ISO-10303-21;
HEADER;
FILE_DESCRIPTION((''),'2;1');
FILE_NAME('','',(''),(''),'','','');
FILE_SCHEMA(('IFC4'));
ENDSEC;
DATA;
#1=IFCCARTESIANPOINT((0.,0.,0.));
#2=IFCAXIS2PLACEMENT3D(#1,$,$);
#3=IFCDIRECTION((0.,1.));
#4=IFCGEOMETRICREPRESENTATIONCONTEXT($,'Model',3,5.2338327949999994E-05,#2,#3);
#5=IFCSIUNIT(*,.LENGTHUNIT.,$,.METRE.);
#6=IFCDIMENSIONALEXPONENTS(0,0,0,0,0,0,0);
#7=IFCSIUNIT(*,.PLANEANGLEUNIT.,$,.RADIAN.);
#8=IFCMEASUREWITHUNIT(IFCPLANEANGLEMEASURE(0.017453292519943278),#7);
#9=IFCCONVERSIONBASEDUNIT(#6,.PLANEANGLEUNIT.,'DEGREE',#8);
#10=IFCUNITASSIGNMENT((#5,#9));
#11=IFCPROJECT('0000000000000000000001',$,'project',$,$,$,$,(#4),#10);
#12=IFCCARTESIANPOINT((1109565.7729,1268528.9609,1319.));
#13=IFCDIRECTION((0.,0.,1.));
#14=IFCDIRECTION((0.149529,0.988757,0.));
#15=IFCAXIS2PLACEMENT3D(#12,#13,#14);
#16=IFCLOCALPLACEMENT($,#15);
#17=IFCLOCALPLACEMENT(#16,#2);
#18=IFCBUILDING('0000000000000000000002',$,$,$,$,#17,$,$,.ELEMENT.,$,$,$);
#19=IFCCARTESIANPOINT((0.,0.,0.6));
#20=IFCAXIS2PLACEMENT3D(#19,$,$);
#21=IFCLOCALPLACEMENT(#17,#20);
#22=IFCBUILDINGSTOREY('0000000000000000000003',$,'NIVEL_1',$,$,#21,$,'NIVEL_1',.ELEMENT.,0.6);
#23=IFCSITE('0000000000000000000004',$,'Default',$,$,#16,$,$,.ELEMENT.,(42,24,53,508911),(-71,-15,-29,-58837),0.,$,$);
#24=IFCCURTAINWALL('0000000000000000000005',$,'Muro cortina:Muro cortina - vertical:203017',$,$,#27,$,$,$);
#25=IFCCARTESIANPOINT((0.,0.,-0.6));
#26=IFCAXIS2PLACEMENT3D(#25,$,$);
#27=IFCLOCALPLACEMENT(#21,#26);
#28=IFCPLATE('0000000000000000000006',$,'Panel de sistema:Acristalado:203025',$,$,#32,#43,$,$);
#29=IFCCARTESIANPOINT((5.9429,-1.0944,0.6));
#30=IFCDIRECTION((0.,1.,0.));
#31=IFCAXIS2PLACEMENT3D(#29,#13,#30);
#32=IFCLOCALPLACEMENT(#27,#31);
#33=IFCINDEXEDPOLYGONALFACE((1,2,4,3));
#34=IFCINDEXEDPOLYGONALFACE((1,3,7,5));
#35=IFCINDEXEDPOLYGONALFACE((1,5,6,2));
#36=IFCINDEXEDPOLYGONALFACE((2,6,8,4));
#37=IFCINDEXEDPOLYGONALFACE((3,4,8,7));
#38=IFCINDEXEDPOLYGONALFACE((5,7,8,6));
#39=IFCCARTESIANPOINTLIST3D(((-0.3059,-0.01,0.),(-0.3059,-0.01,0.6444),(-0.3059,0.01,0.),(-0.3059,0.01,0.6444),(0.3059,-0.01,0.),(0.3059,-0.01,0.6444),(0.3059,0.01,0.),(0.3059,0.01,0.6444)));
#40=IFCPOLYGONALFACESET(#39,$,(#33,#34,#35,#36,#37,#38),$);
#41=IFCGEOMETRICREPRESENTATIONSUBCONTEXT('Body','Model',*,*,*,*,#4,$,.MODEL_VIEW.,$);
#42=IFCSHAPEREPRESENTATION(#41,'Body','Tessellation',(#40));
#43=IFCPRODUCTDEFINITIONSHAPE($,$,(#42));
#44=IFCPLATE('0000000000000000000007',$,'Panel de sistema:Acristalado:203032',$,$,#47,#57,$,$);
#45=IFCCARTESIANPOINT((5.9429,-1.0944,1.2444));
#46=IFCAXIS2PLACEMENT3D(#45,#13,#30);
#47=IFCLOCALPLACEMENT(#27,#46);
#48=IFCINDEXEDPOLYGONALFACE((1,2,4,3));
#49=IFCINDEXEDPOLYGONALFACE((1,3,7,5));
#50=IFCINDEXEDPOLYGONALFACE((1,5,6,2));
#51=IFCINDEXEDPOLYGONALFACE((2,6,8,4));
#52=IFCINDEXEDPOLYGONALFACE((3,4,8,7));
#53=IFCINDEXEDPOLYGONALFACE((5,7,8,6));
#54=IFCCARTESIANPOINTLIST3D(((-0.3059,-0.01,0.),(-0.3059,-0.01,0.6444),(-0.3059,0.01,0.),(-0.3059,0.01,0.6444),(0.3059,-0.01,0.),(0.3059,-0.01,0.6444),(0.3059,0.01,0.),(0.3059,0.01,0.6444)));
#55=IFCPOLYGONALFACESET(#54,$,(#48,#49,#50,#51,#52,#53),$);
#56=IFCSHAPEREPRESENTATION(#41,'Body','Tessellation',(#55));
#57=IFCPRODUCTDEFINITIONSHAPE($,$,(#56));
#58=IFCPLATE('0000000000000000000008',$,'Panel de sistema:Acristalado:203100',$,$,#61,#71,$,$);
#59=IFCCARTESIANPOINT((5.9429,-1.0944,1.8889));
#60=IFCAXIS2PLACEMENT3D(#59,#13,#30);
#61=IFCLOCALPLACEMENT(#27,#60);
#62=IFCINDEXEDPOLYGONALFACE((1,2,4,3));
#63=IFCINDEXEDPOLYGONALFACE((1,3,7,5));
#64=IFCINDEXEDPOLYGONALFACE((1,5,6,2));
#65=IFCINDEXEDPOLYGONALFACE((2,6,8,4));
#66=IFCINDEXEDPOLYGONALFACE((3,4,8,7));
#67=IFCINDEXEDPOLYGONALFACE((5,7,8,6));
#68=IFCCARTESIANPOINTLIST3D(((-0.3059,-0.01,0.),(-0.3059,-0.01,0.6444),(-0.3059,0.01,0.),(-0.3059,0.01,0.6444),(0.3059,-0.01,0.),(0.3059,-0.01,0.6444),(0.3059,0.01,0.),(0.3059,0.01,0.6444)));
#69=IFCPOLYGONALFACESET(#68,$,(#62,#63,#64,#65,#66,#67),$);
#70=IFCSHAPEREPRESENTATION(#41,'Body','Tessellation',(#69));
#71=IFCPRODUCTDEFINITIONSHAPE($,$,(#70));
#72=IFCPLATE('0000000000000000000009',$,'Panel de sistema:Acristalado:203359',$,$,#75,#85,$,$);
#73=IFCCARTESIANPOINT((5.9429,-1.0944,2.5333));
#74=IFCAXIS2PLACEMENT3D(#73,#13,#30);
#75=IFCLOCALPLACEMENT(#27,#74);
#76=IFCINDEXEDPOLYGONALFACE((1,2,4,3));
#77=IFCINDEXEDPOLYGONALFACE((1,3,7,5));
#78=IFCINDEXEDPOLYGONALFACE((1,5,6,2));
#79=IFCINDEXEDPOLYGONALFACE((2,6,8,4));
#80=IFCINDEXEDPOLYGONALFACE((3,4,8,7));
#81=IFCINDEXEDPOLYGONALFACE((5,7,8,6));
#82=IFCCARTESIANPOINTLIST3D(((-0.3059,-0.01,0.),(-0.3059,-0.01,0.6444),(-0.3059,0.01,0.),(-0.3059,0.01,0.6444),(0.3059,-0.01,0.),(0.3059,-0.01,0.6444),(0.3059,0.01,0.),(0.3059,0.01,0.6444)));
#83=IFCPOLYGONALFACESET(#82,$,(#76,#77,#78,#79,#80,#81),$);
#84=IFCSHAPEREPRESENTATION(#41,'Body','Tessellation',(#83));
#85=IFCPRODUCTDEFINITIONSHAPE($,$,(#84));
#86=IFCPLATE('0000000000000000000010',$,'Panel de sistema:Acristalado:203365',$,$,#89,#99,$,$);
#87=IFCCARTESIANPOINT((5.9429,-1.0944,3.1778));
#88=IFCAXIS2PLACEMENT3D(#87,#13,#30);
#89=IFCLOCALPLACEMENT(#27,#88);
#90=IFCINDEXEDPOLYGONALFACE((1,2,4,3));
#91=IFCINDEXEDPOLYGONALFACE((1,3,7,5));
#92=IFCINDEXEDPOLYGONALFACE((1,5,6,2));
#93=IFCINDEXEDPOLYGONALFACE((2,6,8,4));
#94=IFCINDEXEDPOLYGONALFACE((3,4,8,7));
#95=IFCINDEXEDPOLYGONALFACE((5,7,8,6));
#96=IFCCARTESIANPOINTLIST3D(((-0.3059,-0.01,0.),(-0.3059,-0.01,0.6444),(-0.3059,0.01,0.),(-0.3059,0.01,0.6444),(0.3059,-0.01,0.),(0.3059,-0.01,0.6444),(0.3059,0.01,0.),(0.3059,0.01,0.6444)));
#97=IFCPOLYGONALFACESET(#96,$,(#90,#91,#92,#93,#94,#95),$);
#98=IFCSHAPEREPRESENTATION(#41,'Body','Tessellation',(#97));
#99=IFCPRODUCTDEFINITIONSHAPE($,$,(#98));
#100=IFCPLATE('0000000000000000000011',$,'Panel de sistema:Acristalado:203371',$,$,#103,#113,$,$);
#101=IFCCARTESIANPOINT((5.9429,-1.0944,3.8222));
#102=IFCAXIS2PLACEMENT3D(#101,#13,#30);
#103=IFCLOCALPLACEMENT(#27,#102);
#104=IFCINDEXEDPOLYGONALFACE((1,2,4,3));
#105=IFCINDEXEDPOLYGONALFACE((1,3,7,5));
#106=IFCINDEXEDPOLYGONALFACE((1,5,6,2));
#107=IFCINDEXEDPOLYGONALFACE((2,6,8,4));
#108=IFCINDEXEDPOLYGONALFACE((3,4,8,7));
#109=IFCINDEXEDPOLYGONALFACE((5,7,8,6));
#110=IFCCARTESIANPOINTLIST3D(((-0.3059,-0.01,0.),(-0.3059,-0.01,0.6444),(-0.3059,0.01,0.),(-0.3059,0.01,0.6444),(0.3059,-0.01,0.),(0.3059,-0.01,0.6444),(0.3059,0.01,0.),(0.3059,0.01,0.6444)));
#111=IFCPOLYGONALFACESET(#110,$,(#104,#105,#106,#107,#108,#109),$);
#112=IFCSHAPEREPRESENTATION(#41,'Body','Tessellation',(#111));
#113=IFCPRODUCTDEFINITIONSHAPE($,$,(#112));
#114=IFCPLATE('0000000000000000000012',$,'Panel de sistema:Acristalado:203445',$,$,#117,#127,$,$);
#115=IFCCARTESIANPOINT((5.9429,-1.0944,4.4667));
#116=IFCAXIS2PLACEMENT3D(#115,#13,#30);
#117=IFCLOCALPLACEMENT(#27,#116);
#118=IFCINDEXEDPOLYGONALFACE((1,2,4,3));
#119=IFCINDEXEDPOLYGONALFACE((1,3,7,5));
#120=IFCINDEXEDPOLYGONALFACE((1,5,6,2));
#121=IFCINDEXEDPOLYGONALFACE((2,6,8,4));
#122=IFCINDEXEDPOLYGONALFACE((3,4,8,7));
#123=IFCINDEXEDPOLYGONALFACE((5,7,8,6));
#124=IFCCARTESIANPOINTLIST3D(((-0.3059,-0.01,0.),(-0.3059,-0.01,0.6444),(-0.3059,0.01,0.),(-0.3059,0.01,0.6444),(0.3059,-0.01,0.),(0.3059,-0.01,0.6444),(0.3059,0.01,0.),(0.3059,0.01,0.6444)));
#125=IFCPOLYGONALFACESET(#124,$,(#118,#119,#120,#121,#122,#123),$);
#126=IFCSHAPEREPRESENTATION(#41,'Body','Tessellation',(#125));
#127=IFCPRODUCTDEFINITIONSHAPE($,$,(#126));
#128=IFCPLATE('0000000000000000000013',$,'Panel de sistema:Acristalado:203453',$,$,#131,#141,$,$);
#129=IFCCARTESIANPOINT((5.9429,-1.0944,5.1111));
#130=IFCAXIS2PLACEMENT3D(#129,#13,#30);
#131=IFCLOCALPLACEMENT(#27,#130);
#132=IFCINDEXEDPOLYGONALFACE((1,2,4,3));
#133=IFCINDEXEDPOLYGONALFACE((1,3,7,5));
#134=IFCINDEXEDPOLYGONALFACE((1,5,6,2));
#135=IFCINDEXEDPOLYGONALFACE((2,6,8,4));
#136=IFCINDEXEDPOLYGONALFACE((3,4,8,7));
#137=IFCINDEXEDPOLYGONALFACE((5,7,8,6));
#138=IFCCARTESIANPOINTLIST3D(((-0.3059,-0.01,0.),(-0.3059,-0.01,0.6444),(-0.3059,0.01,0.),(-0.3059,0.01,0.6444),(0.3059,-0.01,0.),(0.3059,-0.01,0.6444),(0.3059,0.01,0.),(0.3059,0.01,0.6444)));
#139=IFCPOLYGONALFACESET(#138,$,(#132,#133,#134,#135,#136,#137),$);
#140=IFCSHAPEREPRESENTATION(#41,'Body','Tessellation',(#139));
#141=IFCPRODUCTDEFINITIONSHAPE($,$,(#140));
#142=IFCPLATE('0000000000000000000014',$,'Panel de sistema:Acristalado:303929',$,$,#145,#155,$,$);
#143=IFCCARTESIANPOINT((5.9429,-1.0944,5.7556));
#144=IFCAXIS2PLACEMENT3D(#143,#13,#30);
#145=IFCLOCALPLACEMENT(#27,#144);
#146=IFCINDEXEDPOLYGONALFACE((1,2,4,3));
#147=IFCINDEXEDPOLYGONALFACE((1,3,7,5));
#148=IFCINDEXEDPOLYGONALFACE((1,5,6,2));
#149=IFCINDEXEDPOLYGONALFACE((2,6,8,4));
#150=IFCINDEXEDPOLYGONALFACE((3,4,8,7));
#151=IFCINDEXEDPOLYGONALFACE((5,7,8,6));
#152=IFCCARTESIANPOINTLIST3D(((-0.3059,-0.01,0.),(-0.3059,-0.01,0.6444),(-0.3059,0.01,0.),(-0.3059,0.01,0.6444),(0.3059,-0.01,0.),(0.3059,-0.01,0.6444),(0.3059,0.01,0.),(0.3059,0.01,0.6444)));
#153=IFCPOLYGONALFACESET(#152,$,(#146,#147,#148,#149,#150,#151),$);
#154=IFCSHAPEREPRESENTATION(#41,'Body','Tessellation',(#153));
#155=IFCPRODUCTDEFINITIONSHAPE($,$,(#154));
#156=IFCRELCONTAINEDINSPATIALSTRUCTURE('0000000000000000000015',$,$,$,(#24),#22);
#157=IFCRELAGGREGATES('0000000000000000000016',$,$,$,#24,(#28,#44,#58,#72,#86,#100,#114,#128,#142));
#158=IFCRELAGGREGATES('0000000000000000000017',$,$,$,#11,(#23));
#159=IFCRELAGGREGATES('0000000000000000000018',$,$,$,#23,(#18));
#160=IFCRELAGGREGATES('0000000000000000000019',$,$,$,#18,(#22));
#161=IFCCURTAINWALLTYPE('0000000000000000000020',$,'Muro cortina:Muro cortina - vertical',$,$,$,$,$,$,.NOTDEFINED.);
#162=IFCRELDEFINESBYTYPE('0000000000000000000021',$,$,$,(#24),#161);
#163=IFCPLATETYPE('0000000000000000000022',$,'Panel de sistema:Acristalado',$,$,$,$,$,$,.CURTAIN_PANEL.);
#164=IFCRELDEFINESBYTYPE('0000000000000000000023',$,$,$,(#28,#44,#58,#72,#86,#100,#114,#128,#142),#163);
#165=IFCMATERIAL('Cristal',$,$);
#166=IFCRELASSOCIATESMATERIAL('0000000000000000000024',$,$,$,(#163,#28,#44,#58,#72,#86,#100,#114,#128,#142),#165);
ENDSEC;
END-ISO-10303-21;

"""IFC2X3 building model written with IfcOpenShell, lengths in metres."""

from ifc_helpers import new_model, entity, si_unit, converted_unit, direction, frame, frame_2d, origin, place, context, subcontext, project, spatial, rectangle, extrude, source, transform, mapped, material, type_object, type_shapes, element, aggregate, save


model = new_model("IFC2X3")

# Units and contexts
model_context = context("Model", 3, precision=5.2338327949999994e-05, world=origin(), true_north=direction((0.0, 1.0)))
body_context = subcontext(model_context, "Body", "Model", "MODEL_VIEW")
ifc_project = project(units=[si_unit("LENGTHUNIT", "METRE"), converted_unit("PLANEANGLEUNIT", "DEGREE", entity("IfcPlaneAngleMeasure", 0.017453292519943278), si_unit("PLANEANGLEUNIT", "RADIAN"), dimensions=[0, 0, 0, 0, 0, 0, 0])], contexts=[model_context])

# Site, building, storey
site_placement = place(None, frame((1109565.7729, 1268528.9609, 1319.0), z_axis=(0.0, 0.0, 1.0), x_axis=(0.149529, 0.988757, 0.0)))
site = spatial("IfcSite", under=ifc_project, at=site_placement, Name="Default", CompositionType="ELEMENT", RefLatitude=(42, 24, 53, 508911), RefLongitude=(-71, -15, -29, -58837), RefElevation=0.0)
building_placement = place(site_placement, origin())
building = spatial("IfcBuilding", under=site, at=building_placement, CompositionType="ELEMENT")
storey_placement = place(building_placement, frame((0.0, 0.0, 0.6)))
storey = spatial("IfcBuildingStorey", under=building, at=storey_placement, Name="NIVEL_1", LongName="NIVEL_1", CompositionType="ELEMENT", Elevation=0.6)

# Curtain wall, plates
curtain_wall_type = type_object("IfcCurtainWallType", Name="Muro cortina:Muro cortina - vertical", PredefinedType="NOTDEFINED")
curtain_wall_placement = place(storey_placement, frame((0.0, 0.0, -0.6)))
curtain_wall = element("IfcCurtainWall", 1, at=curtain_wall_placement, inside=storey, type_object=curtain_wall_type, Name="Muro cortina:Muro cortina - vertical:203017")
ifc_material = material(Name="Cristal")
plate_type = type_object("IfcPlateType", Name="Panel de sistema:Acristalado", PredefinedType="CURTAIN_PANEL", material=ifc_material)
shared_shape = source(origin(), body_context, "Body", "SweptSolid", [
    extrude(rectangle(XDim=0.02, YDim=0.6119, at=frame_2d((0.0, 0.0), x_axis=(1.0, 0.0))), frame((0.0, 0.0, 0.0), z_axis=(0.0, 0.0, 1.0), x_axis=(0.0, 1.0, 0.0)), (0.0, 0.0, 1.0), 0.6444),
])
type_shapes(plate_type, [shared_shape])
plate_1_placement = place(curtain_wall_placement, frame((5.9429, -1.0944, 0.6), z_axis=(0.0, 0.0, 1.0), x_axis=(0.0, 1.0, 0.0)))
plate_1 = element("IfcPlate", 2, at=plate_1_placement, type_object=plate_type, material=ifc_material, Name="Panel de sistema:Acristalado:203025", context=body_context, shape_type="MappedRepresentation", body=[
    mapped(shared_shape, transform((0.0, 0.0, 0.0), scale=1.0)),
])
plate_2_placement = place(curtain_wall_placement, frame((5.9429, -1.0944, 1.2444), z_axis=(0.0, 0.0, 1.0), x_axis=(0.0, 1.0, 0.0)))
plate_2 = element("IfcPlate", 3, at=plate_2_placement, type_object=plate_type, material=ifc_material, Name="Panel de sistema:Acristalado:203032", context=body_context, shape_type="MappedRepresentation", body=[
    mapped(shared_shape, transform((0.0, 0.0, 0.0), scale=1.0)),
])
plate_3_placement = place(curtain_wall_placement, frame((5.9429, -1.0944, 1.8889), z_axis=(0.0, 0.0, 1.0), x_axis=(0.0, 1.0, 0.0)))
plate_3 = element("IfcPlate", 4, at=plate_3_placement, type_object=plate_type, material=ifc_material, Name="Panel de sistema:Acristalado:203100", context=body_context, shape_type="MappedRepresentation", body=[
    mapped(shared_shape, transform((0.0, 0.0, 0.0), scale=1.0)),
])
plate_4_placement = place(curtain_wall_placement, frame((5.9429, -1.0944, 2.5333), z_axis=(0.0, 0.0, 1.0), x_axis=(0.0, 1.0, 0.0)))
plate_4 = element("IfcPlate", 5, at=plate_4_placement, type_object=plate_type, material=ifc_material, Name="Panel de sistema:Acristalado:203359", context=body_context, shape_type="MappedRepresentation", body=[
    mapped(shared_shape, transform((0.0, 0.0, 0.0), scale=1.0)),
])
plate_5_placement = place(curtain_wall_placement, frame((5.9429, -1.0944, 3.1778), z_axis=(0.0, 0.0, 1.0), x_axis=(0.0, 1.0, 0.0)))
plate_5 = element("IfcPlate", 6, at=plate_5_placement, type_object=plate_type, material=ifc_material, Name="Panel de sistema:Acristalado:203365", context=body_context, shape_type="MappedRepresentation", body=[
    mapped(shared_shape, transform((0.0, 0.0, 0.0), scale=1.0)),
])
plate_6_placement = place(curtain_wall_placement, frame((5.9429, -1.0944, 3.8222), z_axis=(0.0, 0.0, 1.0), x_axis=(0.0, 1.0, 0.0)))
plate_6 = element("IfcPlate", 7, at=plate_6_placement, type_object=plate_type, material=ifc_material, Name="Panel de sistema:Acristalado:203371", context=body_context, shape_type="MappedRepresentation", body=[
    mapped(shared_shape, transform((0.0, 0.0, 0.0), scale=1.0)),
])
plate_7_placement = place(curtain_wall_placement, frame((5.9429, -1.0944, 4.4667), z_axis=(0.0, 0.0, 1.0), x_axis=(0.0, 1.0, 0.0)))
plate_7 = element("IfcPlate", 8, at=plate_7_placement, type_object=plate_type, material=ifc_material, Name="Panel de sistema:Acristalado:203445", context=body_context, shape_type="MappedRepresentation", body=[
    mapped(shared_shape, transform((0.0, 0.0, 0.0), scale=1.0)),
])
plate_8_placement = place(curtain_wall_placement, frame((5.9429, -1.0944, 5.1111), z_axis=(0.0, 0.0, 1.0), x_axis=(0.0, 1.0, 0.0)))
plate_8 = element("IfcPlate", 9, at=plate_8_placement, type_object=plate_type, material=ifc_material, Name="Panel de sistema:Acristalado:203453", context=body_context, shape_type="MappedRepresentation", body=[
    mapped(shared_shape, transform((0.0, 0.0, 0.0), scale=1.0)),
])
plate_9_placement = place(curtain_wall_placement, frame((5.9429, -1.0944, 5.7556), z_axis=(0.0, 0.0, 1.0), x_axis=(0.0, 1.0, 0.0)))
plate_9 = element("IfcPlate", 10, at=plate_9_placement, type_object=plate_type, material=ifc_material, Name="Panel de sistema:Acristalado:303929", context=body_context, shape_type="MappedRepresentation", body=[
    mapped(shared_shape, transform((0.0, 0.0, 0.0), scale=1.0)),
])
aggregate(curtain_wall, [plate_1, plate_2, plate_3, plate_4, plate_5, plate_6, plate_7, plate_8, plate_9])

save(model, "model.ifc")
